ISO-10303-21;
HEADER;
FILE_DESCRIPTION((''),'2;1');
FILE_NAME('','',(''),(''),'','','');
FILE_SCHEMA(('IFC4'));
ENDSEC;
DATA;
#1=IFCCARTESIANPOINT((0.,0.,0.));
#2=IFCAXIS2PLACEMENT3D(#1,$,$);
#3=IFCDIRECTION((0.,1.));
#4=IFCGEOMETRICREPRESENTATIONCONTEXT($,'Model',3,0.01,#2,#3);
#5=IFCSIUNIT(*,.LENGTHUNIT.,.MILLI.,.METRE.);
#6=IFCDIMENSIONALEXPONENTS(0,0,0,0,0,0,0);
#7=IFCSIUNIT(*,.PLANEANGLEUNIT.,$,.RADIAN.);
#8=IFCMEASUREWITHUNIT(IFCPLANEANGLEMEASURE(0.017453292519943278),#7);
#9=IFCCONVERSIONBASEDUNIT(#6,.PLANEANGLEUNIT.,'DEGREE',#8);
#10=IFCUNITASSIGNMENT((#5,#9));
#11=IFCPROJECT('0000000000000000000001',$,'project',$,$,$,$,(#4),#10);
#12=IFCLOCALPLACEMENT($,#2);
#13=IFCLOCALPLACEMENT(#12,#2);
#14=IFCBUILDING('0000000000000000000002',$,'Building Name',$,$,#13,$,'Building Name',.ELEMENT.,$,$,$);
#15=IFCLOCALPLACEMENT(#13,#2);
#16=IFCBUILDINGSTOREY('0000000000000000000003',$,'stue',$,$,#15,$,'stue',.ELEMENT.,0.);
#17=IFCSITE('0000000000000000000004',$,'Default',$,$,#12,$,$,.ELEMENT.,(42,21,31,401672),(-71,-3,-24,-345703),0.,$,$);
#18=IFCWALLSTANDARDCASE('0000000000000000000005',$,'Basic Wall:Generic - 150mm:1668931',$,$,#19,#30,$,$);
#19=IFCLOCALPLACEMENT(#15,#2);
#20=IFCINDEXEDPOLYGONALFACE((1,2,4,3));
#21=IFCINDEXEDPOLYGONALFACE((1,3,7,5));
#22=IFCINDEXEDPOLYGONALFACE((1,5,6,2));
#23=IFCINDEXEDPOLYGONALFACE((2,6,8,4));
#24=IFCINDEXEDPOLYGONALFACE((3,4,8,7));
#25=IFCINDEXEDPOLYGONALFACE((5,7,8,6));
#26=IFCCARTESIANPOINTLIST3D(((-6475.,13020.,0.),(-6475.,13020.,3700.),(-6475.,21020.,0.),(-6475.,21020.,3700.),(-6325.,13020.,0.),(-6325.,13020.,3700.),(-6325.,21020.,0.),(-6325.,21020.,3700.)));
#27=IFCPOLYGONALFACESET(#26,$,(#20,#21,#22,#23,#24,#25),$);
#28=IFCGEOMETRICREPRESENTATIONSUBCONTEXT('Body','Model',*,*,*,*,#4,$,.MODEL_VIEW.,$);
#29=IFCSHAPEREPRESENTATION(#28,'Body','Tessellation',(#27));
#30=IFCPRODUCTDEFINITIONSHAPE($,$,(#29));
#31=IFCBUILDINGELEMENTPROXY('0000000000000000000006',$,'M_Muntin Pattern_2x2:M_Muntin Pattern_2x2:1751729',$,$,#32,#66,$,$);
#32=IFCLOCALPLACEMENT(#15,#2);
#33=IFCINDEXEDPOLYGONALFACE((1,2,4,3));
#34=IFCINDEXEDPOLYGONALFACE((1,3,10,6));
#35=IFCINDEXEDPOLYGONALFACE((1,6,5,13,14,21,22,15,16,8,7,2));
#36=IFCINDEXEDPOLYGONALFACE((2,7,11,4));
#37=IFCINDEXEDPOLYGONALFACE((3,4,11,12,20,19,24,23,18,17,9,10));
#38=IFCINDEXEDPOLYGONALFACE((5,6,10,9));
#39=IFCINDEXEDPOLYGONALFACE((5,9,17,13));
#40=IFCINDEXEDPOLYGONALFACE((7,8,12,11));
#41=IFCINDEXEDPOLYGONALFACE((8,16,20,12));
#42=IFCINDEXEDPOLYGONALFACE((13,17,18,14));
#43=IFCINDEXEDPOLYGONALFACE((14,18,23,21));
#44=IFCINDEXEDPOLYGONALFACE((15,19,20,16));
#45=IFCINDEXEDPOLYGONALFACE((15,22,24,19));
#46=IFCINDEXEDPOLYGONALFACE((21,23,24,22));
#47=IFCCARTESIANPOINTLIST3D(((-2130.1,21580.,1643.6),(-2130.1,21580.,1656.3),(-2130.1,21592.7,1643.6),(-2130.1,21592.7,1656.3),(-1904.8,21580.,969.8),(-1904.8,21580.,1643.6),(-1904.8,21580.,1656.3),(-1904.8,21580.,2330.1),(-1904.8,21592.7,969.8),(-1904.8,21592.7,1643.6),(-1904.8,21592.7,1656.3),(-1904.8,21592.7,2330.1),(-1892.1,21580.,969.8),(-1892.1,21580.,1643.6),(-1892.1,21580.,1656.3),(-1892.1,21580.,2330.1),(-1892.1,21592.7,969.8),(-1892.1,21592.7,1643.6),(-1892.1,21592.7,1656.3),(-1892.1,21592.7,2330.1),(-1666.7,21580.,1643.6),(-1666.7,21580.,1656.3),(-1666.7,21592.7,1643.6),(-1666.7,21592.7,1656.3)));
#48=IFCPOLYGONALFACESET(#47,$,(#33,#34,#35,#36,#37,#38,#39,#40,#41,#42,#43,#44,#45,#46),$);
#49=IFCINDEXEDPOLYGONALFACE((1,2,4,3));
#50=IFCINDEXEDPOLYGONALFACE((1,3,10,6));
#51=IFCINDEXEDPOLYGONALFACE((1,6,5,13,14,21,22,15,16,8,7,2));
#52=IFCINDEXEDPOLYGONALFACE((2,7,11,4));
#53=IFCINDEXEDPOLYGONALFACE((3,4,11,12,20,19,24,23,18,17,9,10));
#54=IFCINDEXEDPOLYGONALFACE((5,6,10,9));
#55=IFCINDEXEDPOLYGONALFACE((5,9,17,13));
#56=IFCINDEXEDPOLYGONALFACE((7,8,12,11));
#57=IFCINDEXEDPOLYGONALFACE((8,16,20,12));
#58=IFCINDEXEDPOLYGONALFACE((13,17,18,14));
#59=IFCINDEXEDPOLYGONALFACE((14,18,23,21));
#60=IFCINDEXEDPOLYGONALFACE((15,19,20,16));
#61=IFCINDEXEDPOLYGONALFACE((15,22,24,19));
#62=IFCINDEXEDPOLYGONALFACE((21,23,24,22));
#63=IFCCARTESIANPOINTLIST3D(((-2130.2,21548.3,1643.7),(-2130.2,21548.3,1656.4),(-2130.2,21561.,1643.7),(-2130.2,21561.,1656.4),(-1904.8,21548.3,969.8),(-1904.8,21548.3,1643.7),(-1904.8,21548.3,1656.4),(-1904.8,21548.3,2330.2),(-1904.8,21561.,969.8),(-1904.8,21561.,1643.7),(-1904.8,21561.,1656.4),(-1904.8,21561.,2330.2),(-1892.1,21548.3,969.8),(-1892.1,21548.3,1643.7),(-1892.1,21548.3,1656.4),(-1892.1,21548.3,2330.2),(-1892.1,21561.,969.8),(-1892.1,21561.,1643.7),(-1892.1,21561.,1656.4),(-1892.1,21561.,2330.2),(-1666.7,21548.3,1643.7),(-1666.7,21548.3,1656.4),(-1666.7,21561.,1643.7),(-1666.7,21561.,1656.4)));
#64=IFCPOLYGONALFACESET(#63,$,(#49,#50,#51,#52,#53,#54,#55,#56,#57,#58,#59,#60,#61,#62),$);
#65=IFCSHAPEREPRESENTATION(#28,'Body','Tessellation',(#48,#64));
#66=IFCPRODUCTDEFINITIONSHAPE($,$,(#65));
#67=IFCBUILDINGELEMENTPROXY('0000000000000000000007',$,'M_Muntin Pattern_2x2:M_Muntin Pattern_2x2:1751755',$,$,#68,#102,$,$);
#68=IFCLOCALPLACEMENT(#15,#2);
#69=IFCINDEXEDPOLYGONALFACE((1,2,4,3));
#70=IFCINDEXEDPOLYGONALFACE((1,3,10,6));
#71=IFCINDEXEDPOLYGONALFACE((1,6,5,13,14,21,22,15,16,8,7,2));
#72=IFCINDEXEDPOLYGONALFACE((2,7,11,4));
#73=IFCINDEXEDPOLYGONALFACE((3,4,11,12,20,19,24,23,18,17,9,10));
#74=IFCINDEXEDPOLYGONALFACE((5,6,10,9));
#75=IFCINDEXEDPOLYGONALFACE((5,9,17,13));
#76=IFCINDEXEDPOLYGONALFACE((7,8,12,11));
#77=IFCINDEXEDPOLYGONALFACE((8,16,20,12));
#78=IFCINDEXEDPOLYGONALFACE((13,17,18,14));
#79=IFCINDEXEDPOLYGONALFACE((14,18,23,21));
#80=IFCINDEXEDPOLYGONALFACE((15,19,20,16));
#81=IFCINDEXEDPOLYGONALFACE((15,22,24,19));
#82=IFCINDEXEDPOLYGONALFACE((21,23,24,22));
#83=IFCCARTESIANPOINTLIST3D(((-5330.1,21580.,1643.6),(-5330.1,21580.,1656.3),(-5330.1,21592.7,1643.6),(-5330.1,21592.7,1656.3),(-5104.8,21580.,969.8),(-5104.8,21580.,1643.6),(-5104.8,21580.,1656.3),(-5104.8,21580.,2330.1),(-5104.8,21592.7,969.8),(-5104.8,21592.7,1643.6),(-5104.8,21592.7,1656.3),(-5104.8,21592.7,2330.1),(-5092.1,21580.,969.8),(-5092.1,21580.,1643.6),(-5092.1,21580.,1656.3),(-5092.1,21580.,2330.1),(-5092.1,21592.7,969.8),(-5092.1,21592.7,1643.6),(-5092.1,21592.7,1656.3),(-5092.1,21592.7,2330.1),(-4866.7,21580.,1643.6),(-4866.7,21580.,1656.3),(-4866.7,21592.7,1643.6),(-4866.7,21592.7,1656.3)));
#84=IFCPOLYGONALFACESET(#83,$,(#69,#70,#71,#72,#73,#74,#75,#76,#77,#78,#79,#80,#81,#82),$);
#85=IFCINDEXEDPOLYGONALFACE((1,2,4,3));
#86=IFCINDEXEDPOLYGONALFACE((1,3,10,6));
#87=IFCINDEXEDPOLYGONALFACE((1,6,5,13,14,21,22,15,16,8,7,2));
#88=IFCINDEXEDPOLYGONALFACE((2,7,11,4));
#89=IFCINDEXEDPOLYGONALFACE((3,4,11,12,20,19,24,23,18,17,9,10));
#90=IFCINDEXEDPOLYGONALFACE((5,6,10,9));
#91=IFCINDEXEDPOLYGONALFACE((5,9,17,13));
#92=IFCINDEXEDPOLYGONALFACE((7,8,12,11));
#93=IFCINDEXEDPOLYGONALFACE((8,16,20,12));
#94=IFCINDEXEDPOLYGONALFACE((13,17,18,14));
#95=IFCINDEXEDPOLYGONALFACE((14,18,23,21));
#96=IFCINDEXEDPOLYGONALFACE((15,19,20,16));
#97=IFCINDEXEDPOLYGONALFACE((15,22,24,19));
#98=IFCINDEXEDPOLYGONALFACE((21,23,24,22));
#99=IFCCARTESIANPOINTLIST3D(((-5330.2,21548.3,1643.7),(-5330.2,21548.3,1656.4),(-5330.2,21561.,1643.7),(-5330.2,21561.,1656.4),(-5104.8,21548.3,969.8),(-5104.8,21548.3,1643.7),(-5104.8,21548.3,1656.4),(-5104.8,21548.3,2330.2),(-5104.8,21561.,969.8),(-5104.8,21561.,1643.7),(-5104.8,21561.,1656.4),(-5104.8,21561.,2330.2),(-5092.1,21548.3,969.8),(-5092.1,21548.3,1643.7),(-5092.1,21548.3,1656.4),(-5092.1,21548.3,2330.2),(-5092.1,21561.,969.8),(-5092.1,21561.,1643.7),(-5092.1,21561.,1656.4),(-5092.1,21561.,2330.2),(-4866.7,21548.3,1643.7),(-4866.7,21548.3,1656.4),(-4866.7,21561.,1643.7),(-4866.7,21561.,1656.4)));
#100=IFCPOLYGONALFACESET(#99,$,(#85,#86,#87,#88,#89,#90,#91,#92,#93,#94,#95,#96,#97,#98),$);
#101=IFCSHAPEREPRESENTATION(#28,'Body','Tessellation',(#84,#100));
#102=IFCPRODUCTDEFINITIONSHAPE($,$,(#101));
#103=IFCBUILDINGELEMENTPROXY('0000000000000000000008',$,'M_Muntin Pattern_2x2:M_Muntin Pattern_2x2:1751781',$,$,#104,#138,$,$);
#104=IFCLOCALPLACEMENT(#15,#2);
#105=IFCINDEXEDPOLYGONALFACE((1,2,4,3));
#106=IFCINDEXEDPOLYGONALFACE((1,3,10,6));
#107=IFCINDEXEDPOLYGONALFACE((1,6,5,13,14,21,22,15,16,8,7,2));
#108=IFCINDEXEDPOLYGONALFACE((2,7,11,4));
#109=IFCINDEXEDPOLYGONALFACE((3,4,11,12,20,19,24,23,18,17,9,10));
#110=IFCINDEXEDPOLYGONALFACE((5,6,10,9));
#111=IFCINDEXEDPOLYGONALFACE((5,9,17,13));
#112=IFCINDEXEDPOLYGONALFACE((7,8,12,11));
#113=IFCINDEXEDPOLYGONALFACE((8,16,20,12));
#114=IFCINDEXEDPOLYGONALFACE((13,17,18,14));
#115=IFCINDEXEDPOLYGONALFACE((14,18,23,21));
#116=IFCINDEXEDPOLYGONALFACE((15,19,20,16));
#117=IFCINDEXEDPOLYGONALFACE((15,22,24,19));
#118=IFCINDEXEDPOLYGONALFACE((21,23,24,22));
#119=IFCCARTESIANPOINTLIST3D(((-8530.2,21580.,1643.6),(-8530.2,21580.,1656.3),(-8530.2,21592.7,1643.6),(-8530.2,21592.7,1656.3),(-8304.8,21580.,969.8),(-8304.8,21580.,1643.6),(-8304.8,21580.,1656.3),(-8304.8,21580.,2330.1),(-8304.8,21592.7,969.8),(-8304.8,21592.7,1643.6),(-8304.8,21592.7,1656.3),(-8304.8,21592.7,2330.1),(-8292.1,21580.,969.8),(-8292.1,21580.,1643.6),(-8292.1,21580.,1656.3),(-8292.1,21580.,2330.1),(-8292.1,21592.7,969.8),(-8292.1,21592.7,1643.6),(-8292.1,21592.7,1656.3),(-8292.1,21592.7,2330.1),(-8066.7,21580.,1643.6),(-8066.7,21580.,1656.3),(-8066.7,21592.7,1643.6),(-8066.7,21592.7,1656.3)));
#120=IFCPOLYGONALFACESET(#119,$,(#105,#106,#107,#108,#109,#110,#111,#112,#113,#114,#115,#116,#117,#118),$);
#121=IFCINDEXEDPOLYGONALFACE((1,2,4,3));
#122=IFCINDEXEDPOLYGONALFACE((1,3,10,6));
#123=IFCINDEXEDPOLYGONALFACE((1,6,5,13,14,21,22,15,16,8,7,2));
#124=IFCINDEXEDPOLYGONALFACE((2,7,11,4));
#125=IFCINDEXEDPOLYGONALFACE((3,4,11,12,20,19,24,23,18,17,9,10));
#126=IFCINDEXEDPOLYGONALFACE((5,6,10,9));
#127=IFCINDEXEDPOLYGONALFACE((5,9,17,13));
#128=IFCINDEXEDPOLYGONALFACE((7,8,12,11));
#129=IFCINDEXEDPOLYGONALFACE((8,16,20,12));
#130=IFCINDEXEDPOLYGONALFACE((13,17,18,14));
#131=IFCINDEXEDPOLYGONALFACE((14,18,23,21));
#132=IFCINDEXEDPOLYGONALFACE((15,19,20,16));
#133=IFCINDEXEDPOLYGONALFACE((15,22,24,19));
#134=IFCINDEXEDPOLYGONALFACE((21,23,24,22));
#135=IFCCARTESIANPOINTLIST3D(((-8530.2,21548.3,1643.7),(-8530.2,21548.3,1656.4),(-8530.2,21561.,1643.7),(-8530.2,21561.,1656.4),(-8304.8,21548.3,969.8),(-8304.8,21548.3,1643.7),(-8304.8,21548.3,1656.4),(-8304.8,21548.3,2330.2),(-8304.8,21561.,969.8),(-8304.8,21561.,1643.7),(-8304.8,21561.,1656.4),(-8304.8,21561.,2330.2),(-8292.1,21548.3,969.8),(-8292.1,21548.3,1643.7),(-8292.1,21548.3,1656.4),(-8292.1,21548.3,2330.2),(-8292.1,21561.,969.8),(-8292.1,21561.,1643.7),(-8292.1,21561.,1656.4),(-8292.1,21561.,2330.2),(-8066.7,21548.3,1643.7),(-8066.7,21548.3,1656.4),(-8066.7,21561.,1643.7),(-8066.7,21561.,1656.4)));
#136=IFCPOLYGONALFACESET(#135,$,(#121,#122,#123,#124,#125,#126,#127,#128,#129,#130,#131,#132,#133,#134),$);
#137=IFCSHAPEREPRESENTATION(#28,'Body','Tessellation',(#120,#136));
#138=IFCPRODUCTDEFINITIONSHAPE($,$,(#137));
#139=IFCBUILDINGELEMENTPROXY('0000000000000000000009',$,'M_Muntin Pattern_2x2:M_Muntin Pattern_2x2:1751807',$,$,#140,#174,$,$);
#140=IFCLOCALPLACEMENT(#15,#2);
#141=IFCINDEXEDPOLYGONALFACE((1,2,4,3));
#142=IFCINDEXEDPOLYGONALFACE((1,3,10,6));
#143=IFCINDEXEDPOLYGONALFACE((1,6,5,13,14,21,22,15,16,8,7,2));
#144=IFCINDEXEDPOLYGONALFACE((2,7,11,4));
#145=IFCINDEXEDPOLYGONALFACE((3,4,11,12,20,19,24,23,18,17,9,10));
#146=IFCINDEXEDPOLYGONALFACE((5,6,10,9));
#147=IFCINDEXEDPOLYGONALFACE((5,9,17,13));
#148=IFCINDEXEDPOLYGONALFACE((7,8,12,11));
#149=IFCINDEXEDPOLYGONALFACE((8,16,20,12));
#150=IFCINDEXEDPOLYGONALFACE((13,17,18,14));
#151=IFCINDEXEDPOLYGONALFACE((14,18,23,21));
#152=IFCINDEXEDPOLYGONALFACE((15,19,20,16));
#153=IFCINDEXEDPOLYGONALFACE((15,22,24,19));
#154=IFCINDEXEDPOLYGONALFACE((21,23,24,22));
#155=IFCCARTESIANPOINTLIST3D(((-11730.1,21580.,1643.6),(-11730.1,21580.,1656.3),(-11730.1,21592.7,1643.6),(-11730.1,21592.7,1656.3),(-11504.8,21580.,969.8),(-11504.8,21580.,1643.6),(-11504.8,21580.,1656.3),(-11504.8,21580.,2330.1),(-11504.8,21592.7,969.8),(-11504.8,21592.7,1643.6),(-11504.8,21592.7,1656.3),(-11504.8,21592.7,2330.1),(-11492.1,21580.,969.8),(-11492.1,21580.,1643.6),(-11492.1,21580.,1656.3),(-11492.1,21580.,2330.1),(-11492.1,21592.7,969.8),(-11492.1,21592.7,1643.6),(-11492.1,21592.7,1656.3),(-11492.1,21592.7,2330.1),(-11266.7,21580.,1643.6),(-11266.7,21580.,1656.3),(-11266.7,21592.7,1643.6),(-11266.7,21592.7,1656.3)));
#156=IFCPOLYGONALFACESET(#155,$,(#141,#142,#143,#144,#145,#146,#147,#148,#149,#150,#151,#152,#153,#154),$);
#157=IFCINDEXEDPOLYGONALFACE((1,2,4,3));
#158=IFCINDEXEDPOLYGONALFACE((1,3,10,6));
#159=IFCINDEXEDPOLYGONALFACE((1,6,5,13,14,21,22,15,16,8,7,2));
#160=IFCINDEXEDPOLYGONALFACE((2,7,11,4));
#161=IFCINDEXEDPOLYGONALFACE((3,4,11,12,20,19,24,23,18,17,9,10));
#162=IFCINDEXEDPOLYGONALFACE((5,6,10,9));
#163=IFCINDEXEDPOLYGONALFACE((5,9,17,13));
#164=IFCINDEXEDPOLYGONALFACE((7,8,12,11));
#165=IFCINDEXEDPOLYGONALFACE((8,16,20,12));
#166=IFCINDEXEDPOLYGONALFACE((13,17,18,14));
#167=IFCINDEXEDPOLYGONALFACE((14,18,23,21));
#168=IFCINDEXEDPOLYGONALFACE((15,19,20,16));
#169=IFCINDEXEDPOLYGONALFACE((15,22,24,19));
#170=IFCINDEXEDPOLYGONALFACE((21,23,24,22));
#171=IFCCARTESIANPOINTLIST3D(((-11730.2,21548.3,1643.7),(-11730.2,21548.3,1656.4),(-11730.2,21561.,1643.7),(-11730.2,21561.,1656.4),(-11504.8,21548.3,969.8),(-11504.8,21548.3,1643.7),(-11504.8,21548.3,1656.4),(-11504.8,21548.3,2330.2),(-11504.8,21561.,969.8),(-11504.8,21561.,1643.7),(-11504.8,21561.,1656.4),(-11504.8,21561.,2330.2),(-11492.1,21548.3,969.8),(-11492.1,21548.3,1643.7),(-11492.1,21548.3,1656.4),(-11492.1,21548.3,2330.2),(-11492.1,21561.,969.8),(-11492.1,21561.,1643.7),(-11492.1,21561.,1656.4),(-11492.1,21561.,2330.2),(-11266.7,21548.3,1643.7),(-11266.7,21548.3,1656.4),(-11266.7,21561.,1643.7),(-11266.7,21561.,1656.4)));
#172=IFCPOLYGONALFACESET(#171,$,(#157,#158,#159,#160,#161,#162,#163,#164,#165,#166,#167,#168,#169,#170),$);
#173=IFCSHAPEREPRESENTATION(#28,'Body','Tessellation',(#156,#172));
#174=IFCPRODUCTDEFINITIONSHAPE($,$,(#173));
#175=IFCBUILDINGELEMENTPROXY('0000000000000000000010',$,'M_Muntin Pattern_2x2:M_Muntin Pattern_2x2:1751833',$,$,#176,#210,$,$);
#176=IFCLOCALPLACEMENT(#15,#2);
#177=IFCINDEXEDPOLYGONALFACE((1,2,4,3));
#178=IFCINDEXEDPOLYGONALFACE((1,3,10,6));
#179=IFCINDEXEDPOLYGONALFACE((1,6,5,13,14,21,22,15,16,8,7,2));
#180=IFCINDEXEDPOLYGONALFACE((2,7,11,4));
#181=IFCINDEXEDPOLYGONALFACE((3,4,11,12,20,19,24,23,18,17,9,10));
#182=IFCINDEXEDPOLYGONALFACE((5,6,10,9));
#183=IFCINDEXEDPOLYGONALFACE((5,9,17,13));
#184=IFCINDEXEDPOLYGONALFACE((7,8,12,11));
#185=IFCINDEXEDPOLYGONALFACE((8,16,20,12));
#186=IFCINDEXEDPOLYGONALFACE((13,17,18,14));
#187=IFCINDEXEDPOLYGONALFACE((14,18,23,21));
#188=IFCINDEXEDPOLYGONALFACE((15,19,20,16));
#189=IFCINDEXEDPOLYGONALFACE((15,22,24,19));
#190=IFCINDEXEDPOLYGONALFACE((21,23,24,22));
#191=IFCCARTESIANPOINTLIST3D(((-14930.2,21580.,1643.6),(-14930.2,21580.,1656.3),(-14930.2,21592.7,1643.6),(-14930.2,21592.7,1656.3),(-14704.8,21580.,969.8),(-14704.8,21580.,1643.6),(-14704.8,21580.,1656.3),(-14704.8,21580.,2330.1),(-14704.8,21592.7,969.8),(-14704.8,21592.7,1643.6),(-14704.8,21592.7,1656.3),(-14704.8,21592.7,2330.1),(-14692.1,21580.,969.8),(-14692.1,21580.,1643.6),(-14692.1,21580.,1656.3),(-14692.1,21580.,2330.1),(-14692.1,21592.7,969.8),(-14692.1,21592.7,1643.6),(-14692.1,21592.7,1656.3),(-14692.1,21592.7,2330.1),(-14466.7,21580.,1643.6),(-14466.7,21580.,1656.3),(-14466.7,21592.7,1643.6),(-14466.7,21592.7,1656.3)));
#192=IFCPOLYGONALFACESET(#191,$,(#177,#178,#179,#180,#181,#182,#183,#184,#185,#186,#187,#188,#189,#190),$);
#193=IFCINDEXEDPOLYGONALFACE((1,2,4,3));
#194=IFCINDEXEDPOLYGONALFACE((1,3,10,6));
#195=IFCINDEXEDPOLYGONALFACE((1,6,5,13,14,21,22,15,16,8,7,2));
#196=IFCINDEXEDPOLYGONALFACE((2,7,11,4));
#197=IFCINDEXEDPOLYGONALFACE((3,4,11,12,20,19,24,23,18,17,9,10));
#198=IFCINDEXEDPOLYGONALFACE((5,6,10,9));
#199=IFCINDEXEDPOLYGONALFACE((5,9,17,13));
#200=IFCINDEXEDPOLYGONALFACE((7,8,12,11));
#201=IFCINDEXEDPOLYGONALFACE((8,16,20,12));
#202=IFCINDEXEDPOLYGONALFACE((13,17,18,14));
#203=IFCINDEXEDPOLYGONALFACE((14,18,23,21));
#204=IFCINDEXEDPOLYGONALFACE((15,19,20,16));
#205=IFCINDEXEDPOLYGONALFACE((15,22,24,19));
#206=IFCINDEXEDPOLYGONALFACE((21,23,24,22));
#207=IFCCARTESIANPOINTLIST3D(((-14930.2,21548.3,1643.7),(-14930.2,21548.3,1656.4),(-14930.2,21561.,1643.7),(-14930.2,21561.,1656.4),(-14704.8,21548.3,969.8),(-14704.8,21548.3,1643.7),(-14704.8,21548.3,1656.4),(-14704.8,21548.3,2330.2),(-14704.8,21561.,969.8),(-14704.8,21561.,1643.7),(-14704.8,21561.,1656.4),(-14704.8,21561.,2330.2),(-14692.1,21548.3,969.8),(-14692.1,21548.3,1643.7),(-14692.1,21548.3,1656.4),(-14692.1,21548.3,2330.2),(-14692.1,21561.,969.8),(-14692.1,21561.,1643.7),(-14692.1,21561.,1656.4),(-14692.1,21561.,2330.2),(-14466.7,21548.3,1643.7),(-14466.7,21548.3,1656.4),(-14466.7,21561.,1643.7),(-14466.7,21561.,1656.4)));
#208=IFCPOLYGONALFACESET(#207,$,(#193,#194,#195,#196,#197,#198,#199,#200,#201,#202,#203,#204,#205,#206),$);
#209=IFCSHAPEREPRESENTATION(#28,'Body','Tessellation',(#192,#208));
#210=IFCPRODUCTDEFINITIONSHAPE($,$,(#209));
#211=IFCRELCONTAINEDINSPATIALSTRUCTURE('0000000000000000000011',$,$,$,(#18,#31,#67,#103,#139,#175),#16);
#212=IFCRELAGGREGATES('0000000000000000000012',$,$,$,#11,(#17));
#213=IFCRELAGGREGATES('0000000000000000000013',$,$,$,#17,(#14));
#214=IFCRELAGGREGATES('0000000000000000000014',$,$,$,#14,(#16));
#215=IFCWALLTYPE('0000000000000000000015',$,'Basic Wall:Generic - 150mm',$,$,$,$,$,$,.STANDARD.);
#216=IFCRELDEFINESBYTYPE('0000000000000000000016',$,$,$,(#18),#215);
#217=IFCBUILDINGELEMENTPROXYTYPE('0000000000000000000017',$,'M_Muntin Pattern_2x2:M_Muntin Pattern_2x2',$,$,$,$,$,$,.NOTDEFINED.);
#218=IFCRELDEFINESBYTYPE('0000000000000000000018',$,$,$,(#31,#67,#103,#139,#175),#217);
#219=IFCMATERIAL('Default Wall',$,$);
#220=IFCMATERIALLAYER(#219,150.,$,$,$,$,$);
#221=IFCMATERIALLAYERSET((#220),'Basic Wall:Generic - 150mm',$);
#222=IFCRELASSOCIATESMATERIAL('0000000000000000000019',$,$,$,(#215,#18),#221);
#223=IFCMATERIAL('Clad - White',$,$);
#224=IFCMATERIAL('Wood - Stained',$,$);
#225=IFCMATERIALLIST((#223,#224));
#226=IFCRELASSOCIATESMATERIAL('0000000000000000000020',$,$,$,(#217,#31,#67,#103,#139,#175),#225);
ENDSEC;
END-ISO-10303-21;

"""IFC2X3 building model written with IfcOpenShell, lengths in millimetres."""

from ifc_helpers import new_model, entity, si_unit, converted_unit, direction, frame, frame_2d, origin, place, context, subcontext, project, spatial, polyline, rectangle, outline, extrude, clip, bounded_halfspace, source, transform, mapped, material, material_list, layer, layer_set, layer_usage, type_object, type_shapes, element, save


model = new_model("IFC2X3")

# Units and contexts
model_context = context("Model", 3, precision=0.01, world=origin(), true_north=direction((0.0, 1.0)))
body_context = subcontext(model_context, "Body", "Model", "MODEL_VIEW")
ifc_project = project(units=[si_unit("LENGTHUNIT", "METRE", prefix="MILLI"), converted_unit("PLANEANGLEUNIT", "DEGREE", entity("IfcPlaneAngleMeasure", 0.017453292519943278), si_unit("PLANEANGLEUNIT", "RADIAN"), dimensions=[0, 0, 0, 0, 0, 0, 0])], contexts=[model_context])

# Site, building, storey
site_placement = place(None, origin())
site = spatial("IfcSite", under=ifc_project, at=site_placement, Name="Default", CompositionType="ELEMENT", RefLatitude=(42, 21, 31, 401672), RefLongitude=(-71, -3, -24, -345703), RefElevation=0.0)
building_placement = place(site_placement, origin())
building = spatial("IfcBuilding", under=site, at=building_placement, Name="Building Name", LongName="Building Name", CompositionType="ELEMENT")
storey_placement = place(building_placement, origin())
storey = spatial("IfcBuildingStorey", under=building, at=storey_placement, Name="stue", LongName="stue", CompositionType="ELEMENT", Elevation=0.0)

# Wall
ifc_material_1 = material(Name="Default Wall")
ifc_layer = layer(ifc_material_1, 150.0)
ifc_layer_set = layer_set([ifc_layer], Name="Basic Wall:Generic - 150mm")
ifc_layer_usage = layer_usage(ifc_layer_set, "AXIS2", "NEGATIVE", 75.0)
wall_type = type_object("IfcWallType", Name="Basic Wall:Generic - 150mm", PredefinedType="STANDARD", material=ifc_layer_set)
wall_placement = place(storey_placement, frame((-6400.0, 21020.0, 0.0), z_axis=(0.0, 0.0, 1.0), x_axis=(0.0, -1.0, 0.0)))
element("IfcWallStandardCase", 1, at=wall_placement, inside=storey, type_object=wall_type, material=ifc_layer_usage, Name="Basic Wall:Generic - 150mm:1668931", context=body_context, shape_type="Clipping", body=[
    clip(extrude(rectangle(XDim=8000.0, YDim=150.0, at=frame_2d((4000.0, 0.0), x_axis=(-1.0, 0.0))), origin(), (0.0, 0.0, 1.0), 3700.0), bounded_halfspace(frame((0.0, -75.0, 3700.0), z_axis=(0.0, 0.0, -1.0), x_axis=(1.0, 0.0, 0.0)), True, frame((0.0, -75.0, 3700.0)), polyline([(0.0, 0.0), (8000.0, 0.0), (8000.0, 150.0), (0.0, 150.0), (0.0, 0.0)]))),
])

# Building element proxies
ifc_material_2 = material(Name="Clad - White")
ifc_material_3 = material(Name="Wood - Stained")
ifc_material_list = material_list([ifc_material_2, ifc_material_3])
building_element_proxy_type_1 = type_object("IfcBuildingElementProxyType", Name="M_Muntin Pattern_2x2:M_Muntin Pattern_2x2", PredefinedType="NOTDEFINED", material=ifc_material_list)
shared_shape_1 = source(origin(), body_context, "Body", "SweptSolid", [
    extrude(outline(polyline([(6.4, -6.4), (680.1, -6.4), (680.1, 6.3), (6.4, 6.3), (6.4, 231.7), (-6.3, 231.7), (-6.3, 6.3), (-680.2, 6.3), (-680.2, -6.4), (-6.3, -6.4), (-6.3, -231.7), (6.4, -231.7), (6.4, -6.4)])), frame((0.0, 9.5, 680.1), z_axis=(0.0, 1.0, 0.0), x_axis=(0.0, 0.0, 1.0)), (0.0, 0.0, 1.0), 12.7),
    extrude(outline(polyline([(6.4, -6.4), (680.2, -6.4), (680.2, 6.3), (6.4, 6.3), (6.4, 231.7), (-6.3, 231.7), (-6.3, 6.3), (-680.2, 6.3), (-680.2, -6.4), (-6.3, -6.4), (-6.3, -231.7), (6.4, -231.7), (6.4, -6.4)])), frame((0.0, -22.2, 680.2), z_axis=(0.0, 1.0, 0.0), x_axis=(0.0, 0.0, 1.0)), (0.0, 0.0, 1.0), 12.7),
])
type_shapes(building_element_proxy_type_1, [shared_shape_1])
for number, where, name in (
    (2, (-1898.4, 21570.5, 969.8), "M_Muntin Pattern_2x2:M_Muntin Pattern_2x2:1751729"),
    (3, (-5098.4, 21570.5, 969.8), "M_Muntin Pattern_2x2:M_Muntin Pattern_2x2:1751755"),
    (4, (-8298.4, 21570.5, 969.8), "M_Muntin Pattern_2x2:M_Muntin Pattern_2x2:1751781"),
    (5, (-11498.4, 21570.5, 969.8), "M_Muntin Pattern_2x2:M_Muntin Pattern_2x2:1751807"),
    (6, (-14698.4, 21570.5, 969.8), "M_Muntin Pattern_2x2:M_Muntin Pattern_2x2:1751833"),
):
    element("IfcBuildingElementProxy", number, at=place(storey_placement, frame(where)), inside=storey, type_object=building_element_proxy_type_1, material=ifc_material_list, Name=name, context=body_context, shape_type="MappedRepresentation", body=[
        mapped(shared_shape_1, transform((0.0, 0.0, 0.0), scale=1.0)),
    ])

save(model, "model.ifc")
